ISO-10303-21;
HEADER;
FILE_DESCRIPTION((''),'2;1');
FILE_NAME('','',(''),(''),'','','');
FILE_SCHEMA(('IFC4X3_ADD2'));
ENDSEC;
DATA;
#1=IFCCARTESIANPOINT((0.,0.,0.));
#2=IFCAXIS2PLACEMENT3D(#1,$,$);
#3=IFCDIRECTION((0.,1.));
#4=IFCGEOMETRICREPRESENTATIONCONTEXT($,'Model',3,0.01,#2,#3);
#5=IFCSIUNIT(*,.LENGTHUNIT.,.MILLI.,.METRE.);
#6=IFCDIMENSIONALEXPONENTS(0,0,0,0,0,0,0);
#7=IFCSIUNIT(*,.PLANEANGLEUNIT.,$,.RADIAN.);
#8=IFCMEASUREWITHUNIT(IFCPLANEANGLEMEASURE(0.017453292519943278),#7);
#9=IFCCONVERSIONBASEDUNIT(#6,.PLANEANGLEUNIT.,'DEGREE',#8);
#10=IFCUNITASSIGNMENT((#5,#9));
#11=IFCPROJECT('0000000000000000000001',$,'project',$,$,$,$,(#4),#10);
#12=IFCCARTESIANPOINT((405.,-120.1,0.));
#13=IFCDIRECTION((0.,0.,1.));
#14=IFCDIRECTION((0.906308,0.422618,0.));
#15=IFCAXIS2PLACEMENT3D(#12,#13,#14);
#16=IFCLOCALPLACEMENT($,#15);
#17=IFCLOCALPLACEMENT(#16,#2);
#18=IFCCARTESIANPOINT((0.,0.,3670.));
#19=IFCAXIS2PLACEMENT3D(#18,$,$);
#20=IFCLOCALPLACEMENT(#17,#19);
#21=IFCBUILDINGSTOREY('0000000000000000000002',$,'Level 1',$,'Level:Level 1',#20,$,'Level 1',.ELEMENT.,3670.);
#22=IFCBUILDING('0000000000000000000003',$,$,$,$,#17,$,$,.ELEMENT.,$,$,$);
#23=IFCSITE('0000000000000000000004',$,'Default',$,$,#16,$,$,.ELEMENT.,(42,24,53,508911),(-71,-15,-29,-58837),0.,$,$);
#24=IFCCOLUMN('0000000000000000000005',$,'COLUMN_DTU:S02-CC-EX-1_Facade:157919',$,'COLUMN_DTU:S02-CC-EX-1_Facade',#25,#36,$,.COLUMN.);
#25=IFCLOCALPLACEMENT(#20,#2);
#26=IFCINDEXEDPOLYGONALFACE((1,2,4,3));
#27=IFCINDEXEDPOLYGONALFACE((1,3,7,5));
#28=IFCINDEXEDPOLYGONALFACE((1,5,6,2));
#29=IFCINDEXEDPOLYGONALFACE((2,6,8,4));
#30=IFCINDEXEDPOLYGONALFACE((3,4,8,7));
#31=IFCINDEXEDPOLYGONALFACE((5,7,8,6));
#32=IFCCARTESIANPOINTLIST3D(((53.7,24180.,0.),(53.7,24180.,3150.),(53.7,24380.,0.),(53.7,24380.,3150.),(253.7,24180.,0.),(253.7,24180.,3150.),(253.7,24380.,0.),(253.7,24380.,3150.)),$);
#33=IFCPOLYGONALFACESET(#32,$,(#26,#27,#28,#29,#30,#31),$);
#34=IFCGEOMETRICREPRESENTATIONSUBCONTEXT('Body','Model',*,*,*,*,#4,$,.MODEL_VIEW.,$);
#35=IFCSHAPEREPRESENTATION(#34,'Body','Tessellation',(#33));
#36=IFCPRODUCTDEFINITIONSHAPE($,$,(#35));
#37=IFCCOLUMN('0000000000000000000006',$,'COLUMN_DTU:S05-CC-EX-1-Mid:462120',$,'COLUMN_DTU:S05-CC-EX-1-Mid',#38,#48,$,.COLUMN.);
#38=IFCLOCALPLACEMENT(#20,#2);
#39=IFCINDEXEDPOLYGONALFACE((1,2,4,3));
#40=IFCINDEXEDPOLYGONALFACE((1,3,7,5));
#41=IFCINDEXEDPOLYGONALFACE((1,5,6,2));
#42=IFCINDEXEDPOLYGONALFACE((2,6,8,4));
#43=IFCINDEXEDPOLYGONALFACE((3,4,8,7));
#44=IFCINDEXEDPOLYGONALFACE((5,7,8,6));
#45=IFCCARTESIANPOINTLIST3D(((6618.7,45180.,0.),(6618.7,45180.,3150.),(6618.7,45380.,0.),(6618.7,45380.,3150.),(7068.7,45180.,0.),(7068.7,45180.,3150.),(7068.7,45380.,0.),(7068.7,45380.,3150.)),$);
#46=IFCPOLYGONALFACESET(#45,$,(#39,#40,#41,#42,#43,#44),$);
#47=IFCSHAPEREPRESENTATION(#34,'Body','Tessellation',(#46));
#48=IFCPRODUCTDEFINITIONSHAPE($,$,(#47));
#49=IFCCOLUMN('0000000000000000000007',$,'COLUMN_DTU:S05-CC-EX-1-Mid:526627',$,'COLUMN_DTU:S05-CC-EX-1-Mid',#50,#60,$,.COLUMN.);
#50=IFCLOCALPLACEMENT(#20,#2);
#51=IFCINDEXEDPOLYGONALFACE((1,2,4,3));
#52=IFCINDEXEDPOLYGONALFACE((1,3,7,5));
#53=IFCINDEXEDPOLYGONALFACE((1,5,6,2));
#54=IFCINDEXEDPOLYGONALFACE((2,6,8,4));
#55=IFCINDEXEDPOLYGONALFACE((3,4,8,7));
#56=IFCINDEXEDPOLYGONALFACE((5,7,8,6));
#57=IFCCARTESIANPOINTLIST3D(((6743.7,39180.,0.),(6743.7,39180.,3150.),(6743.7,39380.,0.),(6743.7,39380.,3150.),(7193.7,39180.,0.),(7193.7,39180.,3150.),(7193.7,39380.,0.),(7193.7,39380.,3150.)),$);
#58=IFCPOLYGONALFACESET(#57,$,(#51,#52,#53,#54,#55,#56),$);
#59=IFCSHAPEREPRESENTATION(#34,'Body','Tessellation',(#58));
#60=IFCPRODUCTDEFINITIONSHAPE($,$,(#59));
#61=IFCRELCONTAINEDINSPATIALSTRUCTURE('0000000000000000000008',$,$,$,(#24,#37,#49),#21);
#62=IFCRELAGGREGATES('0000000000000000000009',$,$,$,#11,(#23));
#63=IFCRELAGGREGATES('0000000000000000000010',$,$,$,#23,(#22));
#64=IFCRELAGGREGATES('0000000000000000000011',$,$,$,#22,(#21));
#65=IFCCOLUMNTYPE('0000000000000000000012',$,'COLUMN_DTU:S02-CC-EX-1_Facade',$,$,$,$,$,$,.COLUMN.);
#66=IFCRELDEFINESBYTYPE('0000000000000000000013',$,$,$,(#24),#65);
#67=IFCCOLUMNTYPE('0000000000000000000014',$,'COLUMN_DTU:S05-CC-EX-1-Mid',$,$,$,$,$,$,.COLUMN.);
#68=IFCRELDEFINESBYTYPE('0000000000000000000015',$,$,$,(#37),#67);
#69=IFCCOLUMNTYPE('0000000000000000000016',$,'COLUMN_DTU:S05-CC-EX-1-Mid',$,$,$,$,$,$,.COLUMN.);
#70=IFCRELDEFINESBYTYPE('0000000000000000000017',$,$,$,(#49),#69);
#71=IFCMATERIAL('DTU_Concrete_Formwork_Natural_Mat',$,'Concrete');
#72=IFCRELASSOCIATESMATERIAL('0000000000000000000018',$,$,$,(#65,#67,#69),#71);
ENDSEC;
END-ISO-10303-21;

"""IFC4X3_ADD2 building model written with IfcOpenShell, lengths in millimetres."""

from ifc_helpers import new_model, entity, si_unit, converted_unit, direction, frame, frame_2d, origin, origin_2d_with_axis, place, context, subcontext, project, spatial, rectangle, extrude, source, transform, mapped, material, material_profile, profile_set, type_object, type_shapes, element, save


model = new_model("IFC4X3_ADD2")

# Units and contexts
model_context = context("Model", 3, precision=0.01, world=origin(), true_north=direction((0.0, 1.0)))
body_context = subcontext(model_context, "Body", "Model", "MODEL_VIEW")
ifc_project = project(units=[si_unit("LENGTHUNIT", "METRE", prefix="MILLI"), converted_unit("PLANEANGLEUNIT", "DEGREE", entity("IfcPlaneAngleMeasure", 0.017453292519943278), si_unit("PLANEANGLEUNIT", "RADIAN"), dimensions=[0, 0, 0, 0, 0, 0, 0])], contexts=[model_context])

# Site, building, storey
site_placement = place(None, frame((405.0, -120.1, 0.0), z_axis=(0.0, 0.0, 1.0), x_axis=(0.906308, 0.422618, 0.0)))
site = spatial("IfcSite", under=ifc_project, at=site_placement, Name="Default", CompositionType="ELEMENT", RefLatitude=(42, 24, 53, 508911), RefLongitude=(-71, -15, -29, -58837), RefElevation=0.0)
building_placement = place(site_placement, origin())
building = spatial("IfcBuilding", under=site, at=building_placement, CompositionType="ELEMENT")
storey_placement = place(building_placement, frame((0.0, 0.0, 3670.0)))
storey = spatial("IfcBuildingStorey", under=building, at=storey_placement, Name="Level 1", ObjectType="Level:Level 1", LongName="Level 1", CompositionType="ELEMENT", Elevation=3670.0)

# Columns
ifc_material = material(Name="DTU_Concrete_Formwork_Natural_Mat", Category="Concrete")
ifc_material_profile_1 = material_profile(ifc_material, rectangle(XDim=200.0, YDim=200.0, at=frame_2d((0.0, 0.0), x_axis=(1.0, 0.0))), Name="S02-CC-EX-1_Facade")
ifc_profile_set_1 = profile_set([ifc_material_profile_1], Name="S02-CC-EX-1_Facade")
ifc_material_profile_2 = material_profile(ifc_material, rectangle(XDim=200.0, YDim=450.0, at=origin_2d_with_axis()), Name="S05-CC-EX-1-Mid")
ifc_profile_set_2 = profile_set([ifc_material_profile_2], Name="S05-CC-EX-1-Mid")
column_type_1 = type_object("IfcColumnType", Name="COLUMN_DTU:S02-CC-EX-1_Facade", PredefinedType="COLUMN", material=ifc_profile_set_1)
shared_shape_1 = source(origin(), body_context, "Body", "SweptSolid", [
    extrude(rectangle(XDim=200.0, YDim=200.0, at=frame_2d((0.0, 0.0), x_axis=(1.0, 0.0))), frame((153.7, 24280.0, 3670.0), z_axis=(0.0, 0.0, 1.0), x_axis=(0.0, -1.0, 0.0)), (0.0, 0.0, 1.0), 3150.0),
])
type_shapes(column_type_1, [shared_shape_1])
column_1_placement = place(storey_placement, frame((0.0, 0.0, -3670.0)))
element("IfcColumn", 1, at=column_1_placement, inside=storey, type_object=column_type_1, Name="COLUMN_DTU:S02-CC-EX-1_Facade:157919", ObjectType="COLUMN_DTU:S02-CC-EX-1_Facade", PredefinedType="COLUMN", context=body_context, shape_type="MappedRepresentation", body=[
    mapped(shared_shape_1, transform((0.0, 0.0, 0.0), scale=1.0)),
])
column_type_2 = type_object("IfcColumnType", Name="COLUMN_DTU:S05-CC-EX-1-Mid", PredefinedType="COLUMN", material=ifc_profile_set_2)
shared_shape_2 = source(origin(), body_context, "Body", "SweptSolid", [
    extrude(rectangle(XDim=200.0, YDim=450.0, at=frame_2d((0.0, 0.0), x_axis=(1.0, 0.0))), frame((6843.7, 45280.0, 3670.0), z_axis=(0.0, 0.0, 1.0), x_axis=(0.0, 1.0, 0.0)), (0.0, 0.0, 1.0), 3150.0),
])
type_shapes(column_type_2, [shared_shape_2])
column_2_placement = place(storey_placement, frame((0.0, 0.0, -3670.0)))
element("IfcColumn", 2, at=column_2_placement, inside=storey, type_object=column_type_2, Name="COLUMN_DTU:S05-CC-EX-1-Mid:462120", ObjectType="COLUMN_DTU:S05-CC-EX-1-Mid", PredefinedType="COLUMN", context=body_context, shape_type="MappedRepresentation", body=[
    mapped(shared_shape_2, transform((0.0, 0.0, 0.0), scale=1.0)),
])
column_type_3 = type_object("IfcColumnType", Name="COLUMN_DTU:S05-CC-EX-1-Mid", PredefinedType="COLUMN", material=ifc_profile_set_2)
shared_shape_3 = source(origin(), body_context, "Body", "SweptSolid", [
    extrude(rectangle(XDim=200.0, YDim=450.0, at=frame_2d((0.0, 0.0), x_axis=(1.0, 0.0))), frame((6968.7, 39280.0, 3670.0), z_axis=(0.0, 0.0, 1.0), x_axis=(0.0, 1.0, 0.0)), (0.0, 0.0, 1.0), 3150.0),
])
type_shapes(column_type_3, [shared_shape_3])
column_3_placement = place(storey_placement, frame((0.0, 0.0, -3670.0)))
element("IfcColumn", 3, at=column_3_placement, inside=storey, type_object=column_type_3, Name="COLUMN_DTU:S05-CC-EX-1-Mid:526627", ObjectType="COLUMN_DTU:S05-CC-EX-1-Mid", PredefinedType="COLUMN", context=body_context, shape_type="MappedRepresentation", body=[
    mapped(shared_shape_3, transform((0.0, 0.0, 0.0), scale=1.0)),
])

save(model, "model.ifc")
